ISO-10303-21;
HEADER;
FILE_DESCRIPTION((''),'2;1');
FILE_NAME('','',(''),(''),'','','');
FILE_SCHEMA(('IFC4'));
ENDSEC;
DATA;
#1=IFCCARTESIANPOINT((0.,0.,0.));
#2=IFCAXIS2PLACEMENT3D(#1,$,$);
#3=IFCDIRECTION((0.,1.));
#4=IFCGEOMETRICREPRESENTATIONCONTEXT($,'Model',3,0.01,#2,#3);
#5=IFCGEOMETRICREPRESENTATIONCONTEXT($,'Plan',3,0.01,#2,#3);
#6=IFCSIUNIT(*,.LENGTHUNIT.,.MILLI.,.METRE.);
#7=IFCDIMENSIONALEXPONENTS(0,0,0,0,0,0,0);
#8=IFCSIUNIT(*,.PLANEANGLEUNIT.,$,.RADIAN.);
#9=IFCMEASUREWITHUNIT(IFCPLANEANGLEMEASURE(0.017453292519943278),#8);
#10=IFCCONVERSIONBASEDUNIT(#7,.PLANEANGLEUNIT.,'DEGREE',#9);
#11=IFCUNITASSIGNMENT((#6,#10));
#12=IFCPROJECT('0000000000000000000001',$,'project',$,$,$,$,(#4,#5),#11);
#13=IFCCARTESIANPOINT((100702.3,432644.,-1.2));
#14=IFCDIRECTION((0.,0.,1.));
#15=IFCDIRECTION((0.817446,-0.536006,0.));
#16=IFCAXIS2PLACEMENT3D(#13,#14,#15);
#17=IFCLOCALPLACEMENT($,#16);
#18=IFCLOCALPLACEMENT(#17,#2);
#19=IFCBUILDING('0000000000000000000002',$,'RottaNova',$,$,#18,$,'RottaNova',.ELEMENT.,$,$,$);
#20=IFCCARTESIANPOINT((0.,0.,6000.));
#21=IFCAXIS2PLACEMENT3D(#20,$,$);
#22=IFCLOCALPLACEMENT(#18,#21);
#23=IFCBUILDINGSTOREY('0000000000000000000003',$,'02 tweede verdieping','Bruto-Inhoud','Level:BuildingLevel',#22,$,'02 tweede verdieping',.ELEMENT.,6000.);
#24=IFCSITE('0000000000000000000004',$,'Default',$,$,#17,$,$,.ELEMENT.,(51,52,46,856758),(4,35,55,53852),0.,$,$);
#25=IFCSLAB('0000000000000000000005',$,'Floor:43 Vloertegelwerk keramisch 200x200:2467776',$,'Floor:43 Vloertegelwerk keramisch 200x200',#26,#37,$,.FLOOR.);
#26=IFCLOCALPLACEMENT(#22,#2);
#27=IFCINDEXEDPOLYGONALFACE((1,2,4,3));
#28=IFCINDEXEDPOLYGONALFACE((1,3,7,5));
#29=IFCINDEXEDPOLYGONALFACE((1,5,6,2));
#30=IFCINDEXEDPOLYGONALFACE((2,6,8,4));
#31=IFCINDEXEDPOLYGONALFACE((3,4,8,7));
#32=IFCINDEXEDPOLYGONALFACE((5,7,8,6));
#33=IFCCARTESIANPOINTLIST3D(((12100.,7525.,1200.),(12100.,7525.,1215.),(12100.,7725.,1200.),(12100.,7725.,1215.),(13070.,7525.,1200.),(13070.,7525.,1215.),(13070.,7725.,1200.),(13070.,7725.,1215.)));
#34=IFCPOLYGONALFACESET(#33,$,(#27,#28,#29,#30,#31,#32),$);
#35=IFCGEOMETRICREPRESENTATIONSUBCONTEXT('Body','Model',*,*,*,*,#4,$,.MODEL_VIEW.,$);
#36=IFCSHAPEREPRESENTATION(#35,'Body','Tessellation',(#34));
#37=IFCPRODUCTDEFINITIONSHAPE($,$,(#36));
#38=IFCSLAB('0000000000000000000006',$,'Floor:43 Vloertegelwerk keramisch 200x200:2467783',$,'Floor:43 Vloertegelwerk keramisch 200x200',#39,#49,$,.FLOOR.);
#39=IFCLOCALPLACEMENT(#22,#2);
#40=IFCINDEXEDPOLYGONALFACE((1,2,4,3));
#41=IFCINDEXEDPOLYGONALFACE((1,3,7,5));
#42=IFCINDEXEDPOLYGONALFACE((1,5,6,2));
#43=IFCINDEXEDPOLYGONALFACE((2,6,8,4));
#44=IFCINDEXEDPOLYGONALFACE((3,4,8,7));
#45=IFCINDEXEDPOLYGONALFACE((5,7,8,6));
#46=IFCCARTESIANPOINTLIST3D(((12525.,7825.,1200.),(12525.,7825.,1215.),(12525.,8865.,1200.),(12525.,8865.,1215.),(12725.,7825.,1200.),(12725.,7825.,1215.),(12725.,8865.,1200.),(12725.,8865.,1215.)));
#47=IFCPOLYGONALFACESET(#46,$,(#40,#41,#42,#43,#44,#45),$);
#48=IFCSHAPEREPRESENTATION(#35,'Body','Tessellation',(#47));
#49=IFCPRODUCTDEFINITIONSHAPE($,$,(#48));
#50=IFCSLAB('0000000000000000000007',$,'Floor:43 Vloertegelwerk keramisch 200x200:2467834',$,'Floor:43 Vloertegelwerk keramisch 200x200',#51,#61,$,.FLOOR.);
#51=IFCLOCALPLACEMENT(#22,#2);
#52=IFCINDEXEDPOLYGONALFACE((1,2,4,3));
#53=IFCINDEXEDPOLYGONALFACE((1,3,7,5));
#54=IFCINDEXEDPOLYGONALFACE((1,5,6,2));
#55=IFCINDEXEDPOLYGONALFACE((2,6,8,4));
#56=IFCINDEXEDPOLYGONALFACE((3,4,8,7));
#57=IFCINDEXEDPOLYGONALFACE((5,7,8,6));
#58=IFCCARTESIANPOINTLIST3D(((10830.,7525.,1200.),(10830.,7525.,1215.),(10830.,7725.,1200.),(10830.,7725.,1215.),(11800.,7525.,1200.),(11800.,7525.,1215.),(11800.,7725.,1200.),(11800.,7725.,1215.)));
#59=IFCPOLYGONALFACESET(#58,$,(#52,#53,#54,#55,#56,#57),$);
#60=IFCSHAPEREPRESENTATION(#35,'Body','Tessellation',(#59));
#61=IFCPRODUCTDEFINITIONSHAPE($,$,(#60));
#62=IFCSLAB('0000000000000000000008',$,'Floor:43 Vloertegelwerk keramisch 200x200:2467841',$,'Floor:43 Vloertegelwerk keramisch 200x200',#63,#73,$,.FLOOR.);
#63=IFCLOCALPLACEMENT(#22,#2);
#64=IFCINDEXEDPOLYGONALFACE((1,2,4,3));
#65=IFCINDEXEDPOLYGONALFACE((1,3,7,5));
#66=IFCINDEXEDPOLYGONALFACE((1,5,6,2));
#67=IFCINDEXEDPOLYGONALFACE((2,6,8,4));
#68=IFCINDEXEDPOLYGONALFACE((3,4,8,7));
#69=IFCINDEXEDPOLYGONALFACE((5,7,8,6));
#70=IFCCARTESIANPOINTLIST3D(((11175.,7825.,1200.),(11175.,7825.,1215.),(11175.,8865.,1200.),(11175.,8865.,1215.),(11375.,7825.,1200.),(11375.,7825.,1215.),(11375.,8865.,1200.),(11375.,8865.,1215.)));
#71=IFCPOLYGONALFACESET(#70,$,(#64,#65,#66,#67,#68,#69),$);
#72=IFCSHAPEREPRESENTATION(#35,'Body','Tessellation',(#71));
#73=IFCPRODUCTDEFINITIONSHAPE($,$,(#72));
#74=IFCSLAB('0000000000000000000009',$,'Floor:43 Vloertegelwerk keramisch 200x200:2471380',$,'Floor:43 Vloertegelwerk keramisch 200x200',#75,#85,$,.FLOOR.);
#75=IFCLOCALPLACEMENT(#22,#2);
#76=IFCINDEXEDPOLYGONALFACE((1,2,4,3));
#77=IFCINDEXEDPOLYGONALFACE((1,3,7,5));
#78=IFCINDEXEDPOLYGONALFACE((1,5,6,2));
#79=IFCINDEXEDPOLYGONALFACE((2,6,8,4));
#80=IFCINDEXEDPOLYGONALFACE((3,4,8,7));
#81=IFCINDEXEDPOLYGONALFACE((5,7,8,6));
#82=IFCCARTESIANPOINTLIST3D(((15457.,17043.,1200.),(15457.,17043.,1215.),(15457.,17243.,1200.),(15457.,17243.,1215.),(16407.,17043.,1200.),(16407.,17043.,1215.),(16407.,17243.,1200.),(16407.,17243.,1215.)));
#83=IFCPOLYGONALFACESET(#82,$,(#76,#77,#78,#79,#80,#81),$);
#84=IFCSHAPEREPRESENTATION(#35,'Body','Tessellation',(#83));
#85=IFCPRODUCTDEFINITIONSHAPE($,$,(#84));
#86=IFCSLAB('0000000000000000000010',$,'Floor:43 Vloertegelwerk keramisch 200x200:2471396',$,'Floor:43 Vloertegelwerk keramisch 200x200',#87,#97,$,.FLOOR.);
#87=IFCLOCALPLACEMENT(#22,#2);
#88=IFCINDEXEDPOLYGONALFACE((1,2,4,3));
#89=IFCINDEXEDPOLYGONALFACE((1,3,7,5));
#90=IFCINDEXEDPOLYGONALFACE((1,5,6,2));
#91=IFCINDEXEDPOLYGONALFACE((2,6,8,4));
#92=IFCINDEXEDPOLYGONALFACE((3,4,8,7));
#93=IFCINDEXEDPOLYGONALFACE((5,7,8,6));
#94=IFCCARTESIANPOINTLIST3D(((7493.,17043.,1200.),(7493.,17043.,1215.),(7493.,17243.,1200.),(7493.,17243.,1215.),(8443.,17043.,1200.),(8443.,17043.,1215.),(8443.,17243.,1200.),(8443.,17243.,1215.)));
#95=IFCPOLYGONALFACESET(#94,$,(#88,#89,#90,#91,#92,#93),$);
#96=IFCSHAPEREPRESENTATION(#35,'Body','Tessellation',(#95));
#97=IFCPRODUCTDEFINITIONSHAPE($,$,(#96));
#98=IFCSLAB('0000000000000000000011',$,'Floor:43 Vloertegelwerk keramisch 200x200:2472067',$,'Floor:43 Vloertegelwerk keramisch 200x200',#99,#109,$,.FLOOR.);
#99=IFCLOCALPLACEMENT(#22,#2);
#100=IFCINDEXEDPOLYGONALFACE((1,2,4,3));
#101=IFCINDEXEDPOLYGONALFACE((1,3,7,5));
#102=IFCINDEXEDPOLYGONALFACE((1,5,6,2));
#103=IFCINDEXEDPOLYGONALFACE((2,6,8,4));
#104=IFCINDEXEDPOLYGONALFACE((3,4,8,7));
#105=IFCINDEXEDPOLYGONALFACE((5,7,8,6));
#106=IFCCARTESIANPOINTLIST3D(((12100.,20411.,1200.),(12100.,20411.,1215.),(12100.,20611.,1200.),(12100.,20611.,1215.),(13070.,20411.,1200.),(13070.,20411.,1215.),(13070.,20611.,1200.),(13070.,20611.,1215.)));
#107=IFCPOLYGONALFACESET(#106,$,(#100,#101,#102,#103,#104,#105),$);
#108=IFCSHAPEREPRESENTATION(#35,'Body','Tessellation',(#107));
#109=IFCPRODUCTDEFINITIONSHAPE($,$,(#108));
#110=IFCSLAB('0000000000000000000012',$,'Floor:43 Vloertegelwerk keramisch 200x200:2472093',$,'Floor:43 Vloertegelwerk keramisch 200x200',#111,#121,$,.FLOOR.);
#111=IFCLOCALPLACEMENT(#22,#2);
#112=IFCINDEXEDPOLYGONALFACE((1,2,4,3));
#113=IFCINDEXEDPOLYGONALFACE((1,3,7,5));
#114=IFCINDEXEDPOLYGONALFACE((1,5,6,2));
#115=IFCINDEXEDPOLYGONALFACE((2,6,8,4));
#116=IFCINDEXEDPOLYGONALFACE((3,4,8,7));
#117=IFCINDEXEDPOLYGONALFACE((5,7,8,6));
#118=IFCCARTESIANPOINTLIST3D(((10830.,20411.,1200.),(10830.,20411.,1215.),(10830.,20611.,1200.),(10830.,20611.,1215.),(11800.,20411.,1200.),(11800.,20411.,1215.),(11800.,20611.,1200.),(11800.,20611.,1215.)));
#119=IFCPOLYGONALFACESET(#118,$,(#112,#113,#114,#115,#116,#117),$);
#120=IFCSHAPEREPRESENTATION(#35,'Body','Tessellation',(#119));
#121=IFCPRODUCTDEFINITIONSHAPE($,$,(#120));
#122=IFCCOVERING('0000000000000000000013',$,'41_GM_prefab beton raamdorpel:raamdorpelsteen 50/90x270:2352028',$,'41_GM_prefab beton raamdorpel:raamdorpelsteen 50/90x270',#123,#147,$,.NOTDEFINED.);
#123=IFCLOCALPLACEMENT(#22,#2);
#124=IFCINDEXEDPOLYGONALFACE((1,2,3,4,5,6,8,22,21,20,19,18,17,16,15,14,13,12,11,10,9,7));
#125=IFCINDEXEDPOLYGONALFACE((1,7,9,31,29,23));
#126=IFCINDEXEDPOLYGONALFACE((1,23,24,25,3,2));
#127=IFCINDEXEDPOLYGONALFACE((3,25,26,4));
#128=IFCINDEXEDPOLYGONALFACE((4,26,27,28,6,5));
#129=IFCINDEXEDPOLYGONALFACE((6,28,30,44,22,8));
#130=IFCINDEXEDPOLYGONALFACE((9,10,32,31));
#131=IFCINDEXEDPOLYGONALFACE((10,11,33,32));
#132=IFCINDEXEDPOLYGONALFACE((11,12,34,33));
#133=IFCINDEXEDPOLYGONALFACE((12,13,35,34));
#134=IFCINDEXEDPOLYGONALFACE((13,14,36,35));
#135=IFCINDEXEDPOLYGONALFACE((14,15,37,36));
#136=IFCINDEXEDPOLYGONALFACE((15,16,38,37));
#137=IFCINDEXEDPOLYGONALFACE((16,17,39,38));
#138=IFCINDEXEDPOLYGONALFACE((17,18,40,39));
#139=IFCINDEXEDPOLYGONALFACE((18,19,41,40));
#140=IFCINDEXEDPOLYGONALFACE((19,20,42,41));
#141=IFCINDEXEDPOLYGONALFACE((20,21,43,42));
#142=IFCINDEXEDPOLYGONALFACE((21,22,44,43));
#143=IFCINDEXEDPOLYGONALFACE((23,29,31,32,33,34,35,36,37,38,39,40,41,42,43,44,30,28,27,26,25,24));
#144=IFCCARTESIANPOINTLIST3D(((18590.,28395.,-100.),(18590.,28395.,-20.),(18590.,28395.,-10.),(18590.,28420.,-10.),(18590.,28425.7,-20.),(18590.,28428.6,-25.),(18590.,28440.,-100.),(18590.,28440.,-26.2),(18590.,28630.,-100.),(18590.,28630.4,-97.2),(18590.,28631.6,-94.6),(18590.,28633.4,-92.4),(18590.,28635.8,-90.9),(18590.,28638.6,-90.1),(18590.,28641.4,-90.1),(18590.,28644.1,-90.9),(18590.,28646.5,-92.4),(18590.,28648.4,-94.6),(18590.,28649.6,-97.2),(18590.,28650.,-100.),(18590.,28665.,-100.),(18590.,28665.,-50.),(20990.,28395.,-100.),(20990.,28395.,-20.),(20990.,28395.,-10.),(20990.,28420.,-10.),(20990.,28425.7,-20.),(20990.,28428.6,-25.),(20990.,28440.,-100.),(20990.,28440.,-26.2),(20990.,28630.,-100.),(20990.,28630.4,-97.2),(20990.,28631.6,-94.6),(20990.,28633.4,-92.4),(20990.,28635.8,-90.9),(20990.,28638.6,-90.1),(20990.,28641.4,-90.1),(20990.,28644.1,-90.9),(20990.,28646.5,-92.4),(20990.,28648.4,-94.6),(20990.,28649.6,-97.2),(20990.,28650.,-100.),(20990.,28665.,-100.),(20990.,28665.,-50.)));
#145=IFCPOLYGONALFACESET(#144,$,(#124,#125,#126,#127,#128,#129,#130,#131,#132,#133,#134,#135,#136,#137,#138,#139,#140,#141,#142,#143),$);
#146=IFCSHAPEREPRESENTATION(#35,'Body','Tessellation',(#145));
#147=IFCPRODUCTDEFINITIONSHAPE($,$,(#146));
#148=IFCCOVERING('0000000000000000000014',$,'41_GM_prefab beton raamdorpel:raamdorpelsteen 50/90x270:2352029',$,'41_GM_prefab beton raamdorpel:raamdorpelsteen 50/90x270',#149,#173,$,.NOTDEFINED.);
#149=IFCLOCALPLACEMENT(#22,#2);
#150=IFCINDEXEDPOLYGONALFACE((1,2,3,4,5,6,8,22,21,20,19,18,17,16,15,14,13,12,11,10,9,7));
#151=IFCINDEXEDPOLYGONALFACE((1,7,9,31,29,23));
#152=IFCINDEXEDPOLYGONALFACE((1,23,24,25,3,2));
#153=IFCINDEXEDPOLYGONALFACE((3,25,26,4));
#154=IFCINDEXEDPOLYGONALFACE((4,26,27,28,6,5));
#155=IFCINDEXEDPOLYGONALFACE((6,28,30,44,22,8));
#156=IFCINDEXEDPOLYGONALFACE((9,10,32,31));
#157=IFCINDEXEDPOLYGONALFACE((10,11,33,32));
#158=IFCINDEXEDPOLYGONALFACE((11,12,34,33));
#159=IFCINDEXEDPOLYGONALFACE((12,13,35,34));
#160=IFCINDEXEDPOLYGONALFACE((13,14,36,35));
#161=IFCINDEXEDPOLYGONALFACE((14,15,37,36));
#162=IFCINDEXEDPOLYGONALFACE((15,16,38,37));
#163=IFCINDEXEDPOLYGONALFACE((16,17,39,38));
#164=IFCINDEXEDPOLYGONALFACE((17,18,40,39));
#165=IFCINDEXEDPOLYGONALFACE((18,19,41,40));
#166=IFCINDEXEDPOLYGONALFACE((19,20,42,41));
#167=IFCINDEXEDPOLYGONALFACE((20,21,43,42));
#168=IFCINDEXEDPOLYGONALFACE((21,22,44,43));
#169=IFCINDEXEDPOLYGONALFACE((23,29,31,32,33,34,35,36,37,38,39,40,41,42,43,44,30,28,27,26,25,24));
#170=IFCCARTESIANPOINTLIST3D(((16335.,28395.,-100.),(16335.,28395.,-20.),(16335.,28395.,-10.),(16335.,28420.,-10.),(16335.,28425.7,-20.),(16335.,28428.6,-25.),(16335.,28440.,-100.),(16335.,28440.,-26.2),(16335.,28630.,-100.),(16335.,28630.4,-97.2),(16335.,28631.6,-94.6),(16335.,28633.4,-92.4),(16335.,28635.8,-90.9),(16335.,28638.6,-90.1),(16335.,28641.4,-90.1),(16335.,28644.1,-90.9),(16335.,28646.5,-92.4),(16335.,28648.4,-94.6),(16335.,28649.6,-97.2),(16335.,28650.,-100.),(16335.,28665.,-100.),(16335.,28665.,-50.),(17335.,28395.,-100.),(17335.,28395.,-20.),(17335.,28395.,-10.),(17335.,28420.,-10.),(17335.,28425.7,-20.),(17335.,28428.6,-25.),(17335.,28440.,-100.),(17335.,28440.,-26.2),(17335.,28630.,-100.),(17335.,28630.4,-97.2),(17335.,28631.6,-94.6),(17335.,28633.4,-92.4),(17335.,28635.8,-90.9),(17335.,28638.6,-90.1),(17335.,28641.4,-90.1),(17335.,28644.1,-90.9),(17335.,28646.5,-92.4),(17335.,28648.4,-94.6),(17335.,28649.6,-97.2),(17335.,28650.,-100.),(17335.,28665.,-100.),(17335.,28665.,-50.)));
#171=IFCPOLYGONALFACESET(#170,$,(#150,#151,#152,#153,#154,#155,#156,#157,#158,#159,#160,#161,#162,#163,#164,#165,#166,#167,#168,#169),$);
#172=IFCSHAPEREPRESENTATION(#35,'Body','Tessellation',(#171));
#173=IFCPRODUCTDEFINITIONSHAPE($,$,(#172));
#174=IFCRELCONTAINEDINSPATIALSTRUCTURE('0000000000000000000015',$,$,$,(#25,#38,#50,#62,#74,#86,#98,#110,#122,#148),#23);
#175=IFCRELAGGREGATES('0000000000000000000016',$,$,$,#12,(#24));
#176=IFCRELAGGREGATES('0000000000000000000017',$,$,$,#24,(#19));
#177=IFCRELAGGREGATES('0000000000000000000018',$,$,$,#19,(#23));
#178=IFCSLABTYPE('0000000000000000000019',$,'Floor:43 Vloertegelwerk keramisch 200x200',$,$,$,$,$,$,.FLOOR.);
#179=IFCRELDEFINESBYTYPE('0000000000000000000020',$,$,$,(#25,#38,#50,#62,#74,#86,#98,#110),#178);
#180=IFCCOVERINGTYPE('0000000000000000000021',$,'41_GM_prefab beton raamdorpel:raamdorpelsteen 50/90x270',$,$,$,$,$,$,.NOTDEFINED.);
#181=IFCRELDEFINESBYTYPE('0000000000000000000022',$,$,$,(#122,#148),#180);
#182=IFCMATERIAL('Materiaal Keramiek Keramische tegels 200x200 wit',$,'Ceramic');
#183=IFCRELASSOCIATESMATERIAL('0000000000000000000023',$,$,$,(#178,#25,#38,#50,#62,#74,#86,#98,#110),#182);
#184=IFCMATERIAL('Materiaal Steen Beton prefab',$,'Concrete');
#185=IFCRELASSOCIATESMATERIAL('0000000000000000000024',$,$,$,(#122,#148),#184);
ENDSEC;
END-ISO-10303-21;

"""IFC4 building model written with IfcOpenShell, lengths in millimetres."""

from ifc_helpers import new_model, entity, si_unit, converted_unit, direction, frame, origin, place, context, subcontext, project, spatial, line, arc, indexed_curve, outline, extrude, material, type_object, element, save


model = new_model("IFC4")

# Units and contexts
model_context = context("Model", 3, precision=0.01, world=origin(), true_north=direction((0.0, 1.0)))
plan_context = context("Plan", 3, precision=0.01, world=origin(), true_north=direction((0.0, 1.0)))
body_context = subcontext(model_context, "Body", "Model", "MODEL_VIEW")
ifc_project = project(units=[si_unit("LENGTHUNIT", "METRE", prefix="MILLI"), converted_unit("PLANEANGLEUNIT", "DEGREE", entity("IfcPlaneAngleMeasure", 0.017453292519943278), si_unit("PLANEANGLEUNIT", "RADIAN"), dimensions=[0, 0, 0, 0, 0, 0, 0])], contexts=[model_context, plan_context])

# Site, building, storey
site_placement = place(None, frame((100702.3, 432644.0, -1.2), z_axis=(0.0, 0.0, 1.0), x_axis=(0.817446, -0.536006, 0.0)))
site = spatial("IfcSite", under=ifc_project, at=site_placement, Name="Default", CompositionType="ELEMENT", RefLatitude=(51, 52, 46, 856758), RefLongitude=(4, 35, 55, 53852), RefElevation=0.0)
building_placement = place(site_placement, origin())
building = spatial("IfcBuilding", under=site, at=building_placement, Name="RottaNova", LongName="RottaNova", CompositionType="ELEMENT")
storey_placement = place(building_placement, frame((0.0, 0.0, 6000.0)))
storey = spatial("IfcBuildingStorey", under=building, at=storey_placement, Name="02 tweede verdieping", Description="Bruto-Inhoud", ObjectType="Level:BuildingLevel", LongName="02 tweede verdieping", CompositionType="ELEMENT", Elevation=6000.0)

# Slabs
ifc_material_1 = material(Name="Materiaal Keramiek Keramische tegels 200x200 wit", Category="Ceramic")
slab_type_1 = type_object("IfcSlabType", Name="Floor:43 Vloertegelwerk keramisch 200x200", PredefinedType="FLOOR", material=ifc_material_1)
slab_1_placement = place(storey_placement, origin())
element("IfcSlab", 1, at=slab_1_placement, inside=storey, type_object=slab_type_1, material=ifc_material_1, Name="Floor:43 Vloertegelwerk keramisch 200x200:2467776", ObjectType="Floor:43 Vloertegelwerk keramisch 200x200", PredefinedType="FLOOR", context=body_context, shape_type="SweptSolid", body=[
    extrude(outline(indexed_curve([(-100.0, -485.0), (100.0, -485.0), (100.0, 485.0), (-100.0, 485.0), (-100.0, -485.0)], self_intersect=False)), frame((12585.0, 7625.0, 1215.0), z_axis=(0.0, 0.0, -1.0), x_axis=(0.0, 1.0, 0.0)), (0.0, 0.0, 1.0), 15.0),
])
slab_2_placement = place(storey_placement, origin())
element("IfcSlab", 2, at=slab_2_placement, inside=storey, type_object=slab_type_1, material=ifc_material_1, Name="Floor:43 Vloertegelwerk keramisch 200x200:2467783", ObjectType="Floor:43 Vloertegelwerk keramisch 200x200", PredefinedType="FLOOR", context=body_context, shape_type="SweptSolid", body=[
    extrude(outline(indexed_curve([(-520.0, -100.0), (520.0, -100.0), (520.0, 100.0), (-520.0, 100.0), (-520.0, -100.0)], self_intersect=False)), frame((12625.0, 8345.0, 1215.0), z_axis=(0.0, 0.0, -1.0), x_axis=(0.0, 1.0, 0.0)), (0.0, 0.0, 1.0), 15.0),
])
slab_3_placement = place(storey_placement, origin())
element("IfcSlab", 3, at=slab_3_placement, inside=storey, type_object=slab_type_1, material=ifc_material_1, Name="Floor:43 Vloertegelwerk keramisch 200x200:2467834", ObjectType="Floor:43 Vloertegelwerk keramisch 200x200", PredefinedType="FLOOR", context=body_context, shape_type="SweptSolid", body=[
    extrude(outline(indexed_curve([(-100.0, -485.0), (100.0, -485.0), (100.0, 485.0), (-100.0, 485.0), (-100.0, -485.0)], self_intersect=False)), frame((11315.0, 7625.0, 1215.0), z_axis=(0.0, 0.0, -1.0), x_axis=(0.0, 1.0, 0.0)), (0.0, 0.0, 1.0), 15.0),
])
slab_4_placement = place(storey_placement, origin())
element("IfcSlab", 4, at=slab_4_placement, inside=storey, type_object=slab_type_1, material=ifc_material_1, Name="Floor:43 Vloertegelwerk keramisch 200x200:2467841", ObjectType="Floor:43 Vloertegelwerk keramisch 200x200", PredefinedType="FLOOR", context=body_context, shape_type="SweptSolid", body=[
    extrude(outline(indexed_curve([(-520.0, -100.0), (520.0, -100.0), (520.0, 100.0), (-520.0, 100.0), (-520.0, -100.0)], self_intersect=False)), frame((11275.0, 8345.0, 1215.0), z_axis=(0.0, 0.0, -1.0), x_axis=(0.0, 1.0, 0.0)), (0.0, 0.0, 1.0), 15.0),
])
slab_5_placement = place(storey_placement, origin())
element("IfcSlab", 5, at=slab_5_placement, inside=storey, type_object=slab_type_1, material=ifc_material_1, Name="Floor:43 Vloertegelwerk keramisch 200x200:2471380", ObjectType="Floor:43 Vloertegelwerk keramisch 200x200", PredefinedType="FLOOR", context=body_context, shape_type="SweptSolid", body=[
    extrude(outline(indexed_curve([(-100.0, -475.0), (100.0, -475.0), (100.0, 475.0), (-100.0, 475.0), (-100.0, -475.0)], self_intersect=False)), frame((15932.0, 17143.0, 1215.0), z_axis=(0.0, 0.0, -1.0), x_axis=(0.0, 1.0, 0.0)), (0.0, 0.0, 1.0), 15.0),
])
slab_6_placement = place(storey_placement, origin())
element("IfcSlab", 6, at=slab_6_placement, inside=storey, type_object=slab_type_1, material=ifc_material_1, Name="Floor:43 Vloertegelwerk keramisch 200x200:2471396", ObjectType="Floor:43 Vloertegelwerk keramisch 200x200", PredefinedType="FLOOR", context=body_context, shape_type="SweptSolid", body=[
    extrude(outline(indexed_curve([(-100.0, -475.0), (100.0, -475.0), (100.0, 475.0), (-100.0, 475.0), (-100.0, -475.0)], self_intersect=False)), frame((7968.0, 17143.0, 1215.0), z_axis=(0.0, 0.0, -1.0), x_axis=(0.0, 1.0, 0.0)), (0.0, 0.0, 1.0), 15.0),
])
slab_7_placement = place(storey_placement, origin())
element("IfcSlab", 7, at=slab_7_placement, inside=storey, type_object=slab_type_1, material=ifc_material_1, Name="Floor:43 Vloertegelwerk keramisch 200x200:2472067", ObjectType="Floor:43 Vloertegelwerk keramisch 200x200", PredefinedType="FLOOR", context=body_context, shape_type="SweptSolid", body=[
    extrude(outline(indexed_curve([(-100.0, -485.0), (100.0, -485.0), (100.0, 485.0), (-100.0, 485.0), (-100.0, -485.0)], self_intersect=False)), frame((12585.0, 20511.0, 1215.0), z_axis=(0.0, 0.0, -1.0), x_axis=(0.0, 1.0, 0.0)), (0.0, 0.0, 1.0), 15.0),
])
slab_8_placement = place(storey_placement, origin())
element("IfcSlab", 8, at=slab_8_placement, inside=storey, type_object=slab_type_1, material=ifc_material_1, Name="Floor:43 Vloertegelwerk keramisch 200x200:2472093", ObjectType="Floor:43 Vloertegelwerk keramisch 200x200", PredefinedType="FLOOR", context=body_context, shape_type="SweptSolid", body=[
    extrude(outline(indexed_curve([(-100.0, -485.0), (100.0, -485.0), (100.0, 485.0), (-100.0, 485.0), (-100.0, -485.0)], self_intersect=False)), frame((11315.0, 20511.0, 1215.0), z_axis=(0.0, 0.0, -1.0), x_axis=(0.0, 1.0, 0.0)), (0.0, 0.0, 1.0), 15.0),
])

# Coverings
ifc_material_2 = material(Name="Materiaal Steen Beton prefab", Category="Concrete")
covering_type_1 = type_object("IfcCoveringType", Name="41_GM_prefab beton raamdorpel:raamdorpelsteen 50/90x270", PredefinedType="NOTDEFINED")
covering_1_placement = place(storey_placement, origin())
element("IfcCovering", 9, at=covering_1_placement, inside=storey, type_object=covering_type_1, material=ifc_material_2, Name="41_GM_prefab beton raamdorpel:raamdorpelsteen 50/90x270:2352028", ObjectType="41_GM_prefab beton raamdorpel:raamdorpelsteen 50/90x270", PredefinedType="NOTDEFINED", context=body_context, shape_type="SweptSolid", body=[
    extrude(outline(indexed_curve([(75.8, -45.1), (100.8, -45.1), (100.8, -35.1), (100.8, 44.9), (55.8, 44.9), (-134.2, 44.9), (-144.2, 34.9), (-154.2, 44.9), (-169.2, 44.9), (-169.2, -5.1), (55.8, -28.9), (67.1, -30.1), (70.0, -35.1)], segments=[line(1, 2, 3, 4, 5, 6), arc(6, 7, 8), line(8, 9, 10, 11, 12, 13, 1)], self_intersect=False)), frame((18590.0, 28495.8, -55.1), z_axis=(1.0, 0.0, 0.0), x_axis=(0.0, -1.0, 0.0)), (0.0, 0.0, 1.0), 2400.0),
])
covering_2_placement = place(storey_placement, origin())
element("IfcCovering", 10, at=covering_2_placement, inside=storey, type_object=covering_type_1, material=ifc_material_2, Name="41_GM_prefab beton raamdorpel:raamdorpelsteen 50/90x270:2352029", ObjectType="41_GM_prefab beton raamdorpel:raamdorpelsteen 50/90x270", PredefinedType="NOTDEFINED", context=body_context, shape_type="SweptSolid", body=[
    extrude(outline(indexed_curve([(75.8, -45.1), (100.8, -45.1), (100.8, -35.1), (100.8, 44.9), (55.8, 44.9), (-134.2, 44.9), (-144.2, 34.9), (-154.2, 44.9), (-169.2, 44.9), (-169.2, -5.1), (55.8, -28.9), (67.1, -30.1), (70.0, -35.1)], segments=[line(1, 2, 3, 4, 5, 6), arc(6, 7, 8), line(8, 9, 10, 11, 12, 13, 1)], self_intersect=False)), frame((16335.0, 28495.8, -55.1), z_axis=(1.0, 0.0, 0.0), x_axis=(0.0, -1.0, 0.0)), (0.0, 0.0, 1.0), 1000.0),
])

save(model, "model.ifc")
